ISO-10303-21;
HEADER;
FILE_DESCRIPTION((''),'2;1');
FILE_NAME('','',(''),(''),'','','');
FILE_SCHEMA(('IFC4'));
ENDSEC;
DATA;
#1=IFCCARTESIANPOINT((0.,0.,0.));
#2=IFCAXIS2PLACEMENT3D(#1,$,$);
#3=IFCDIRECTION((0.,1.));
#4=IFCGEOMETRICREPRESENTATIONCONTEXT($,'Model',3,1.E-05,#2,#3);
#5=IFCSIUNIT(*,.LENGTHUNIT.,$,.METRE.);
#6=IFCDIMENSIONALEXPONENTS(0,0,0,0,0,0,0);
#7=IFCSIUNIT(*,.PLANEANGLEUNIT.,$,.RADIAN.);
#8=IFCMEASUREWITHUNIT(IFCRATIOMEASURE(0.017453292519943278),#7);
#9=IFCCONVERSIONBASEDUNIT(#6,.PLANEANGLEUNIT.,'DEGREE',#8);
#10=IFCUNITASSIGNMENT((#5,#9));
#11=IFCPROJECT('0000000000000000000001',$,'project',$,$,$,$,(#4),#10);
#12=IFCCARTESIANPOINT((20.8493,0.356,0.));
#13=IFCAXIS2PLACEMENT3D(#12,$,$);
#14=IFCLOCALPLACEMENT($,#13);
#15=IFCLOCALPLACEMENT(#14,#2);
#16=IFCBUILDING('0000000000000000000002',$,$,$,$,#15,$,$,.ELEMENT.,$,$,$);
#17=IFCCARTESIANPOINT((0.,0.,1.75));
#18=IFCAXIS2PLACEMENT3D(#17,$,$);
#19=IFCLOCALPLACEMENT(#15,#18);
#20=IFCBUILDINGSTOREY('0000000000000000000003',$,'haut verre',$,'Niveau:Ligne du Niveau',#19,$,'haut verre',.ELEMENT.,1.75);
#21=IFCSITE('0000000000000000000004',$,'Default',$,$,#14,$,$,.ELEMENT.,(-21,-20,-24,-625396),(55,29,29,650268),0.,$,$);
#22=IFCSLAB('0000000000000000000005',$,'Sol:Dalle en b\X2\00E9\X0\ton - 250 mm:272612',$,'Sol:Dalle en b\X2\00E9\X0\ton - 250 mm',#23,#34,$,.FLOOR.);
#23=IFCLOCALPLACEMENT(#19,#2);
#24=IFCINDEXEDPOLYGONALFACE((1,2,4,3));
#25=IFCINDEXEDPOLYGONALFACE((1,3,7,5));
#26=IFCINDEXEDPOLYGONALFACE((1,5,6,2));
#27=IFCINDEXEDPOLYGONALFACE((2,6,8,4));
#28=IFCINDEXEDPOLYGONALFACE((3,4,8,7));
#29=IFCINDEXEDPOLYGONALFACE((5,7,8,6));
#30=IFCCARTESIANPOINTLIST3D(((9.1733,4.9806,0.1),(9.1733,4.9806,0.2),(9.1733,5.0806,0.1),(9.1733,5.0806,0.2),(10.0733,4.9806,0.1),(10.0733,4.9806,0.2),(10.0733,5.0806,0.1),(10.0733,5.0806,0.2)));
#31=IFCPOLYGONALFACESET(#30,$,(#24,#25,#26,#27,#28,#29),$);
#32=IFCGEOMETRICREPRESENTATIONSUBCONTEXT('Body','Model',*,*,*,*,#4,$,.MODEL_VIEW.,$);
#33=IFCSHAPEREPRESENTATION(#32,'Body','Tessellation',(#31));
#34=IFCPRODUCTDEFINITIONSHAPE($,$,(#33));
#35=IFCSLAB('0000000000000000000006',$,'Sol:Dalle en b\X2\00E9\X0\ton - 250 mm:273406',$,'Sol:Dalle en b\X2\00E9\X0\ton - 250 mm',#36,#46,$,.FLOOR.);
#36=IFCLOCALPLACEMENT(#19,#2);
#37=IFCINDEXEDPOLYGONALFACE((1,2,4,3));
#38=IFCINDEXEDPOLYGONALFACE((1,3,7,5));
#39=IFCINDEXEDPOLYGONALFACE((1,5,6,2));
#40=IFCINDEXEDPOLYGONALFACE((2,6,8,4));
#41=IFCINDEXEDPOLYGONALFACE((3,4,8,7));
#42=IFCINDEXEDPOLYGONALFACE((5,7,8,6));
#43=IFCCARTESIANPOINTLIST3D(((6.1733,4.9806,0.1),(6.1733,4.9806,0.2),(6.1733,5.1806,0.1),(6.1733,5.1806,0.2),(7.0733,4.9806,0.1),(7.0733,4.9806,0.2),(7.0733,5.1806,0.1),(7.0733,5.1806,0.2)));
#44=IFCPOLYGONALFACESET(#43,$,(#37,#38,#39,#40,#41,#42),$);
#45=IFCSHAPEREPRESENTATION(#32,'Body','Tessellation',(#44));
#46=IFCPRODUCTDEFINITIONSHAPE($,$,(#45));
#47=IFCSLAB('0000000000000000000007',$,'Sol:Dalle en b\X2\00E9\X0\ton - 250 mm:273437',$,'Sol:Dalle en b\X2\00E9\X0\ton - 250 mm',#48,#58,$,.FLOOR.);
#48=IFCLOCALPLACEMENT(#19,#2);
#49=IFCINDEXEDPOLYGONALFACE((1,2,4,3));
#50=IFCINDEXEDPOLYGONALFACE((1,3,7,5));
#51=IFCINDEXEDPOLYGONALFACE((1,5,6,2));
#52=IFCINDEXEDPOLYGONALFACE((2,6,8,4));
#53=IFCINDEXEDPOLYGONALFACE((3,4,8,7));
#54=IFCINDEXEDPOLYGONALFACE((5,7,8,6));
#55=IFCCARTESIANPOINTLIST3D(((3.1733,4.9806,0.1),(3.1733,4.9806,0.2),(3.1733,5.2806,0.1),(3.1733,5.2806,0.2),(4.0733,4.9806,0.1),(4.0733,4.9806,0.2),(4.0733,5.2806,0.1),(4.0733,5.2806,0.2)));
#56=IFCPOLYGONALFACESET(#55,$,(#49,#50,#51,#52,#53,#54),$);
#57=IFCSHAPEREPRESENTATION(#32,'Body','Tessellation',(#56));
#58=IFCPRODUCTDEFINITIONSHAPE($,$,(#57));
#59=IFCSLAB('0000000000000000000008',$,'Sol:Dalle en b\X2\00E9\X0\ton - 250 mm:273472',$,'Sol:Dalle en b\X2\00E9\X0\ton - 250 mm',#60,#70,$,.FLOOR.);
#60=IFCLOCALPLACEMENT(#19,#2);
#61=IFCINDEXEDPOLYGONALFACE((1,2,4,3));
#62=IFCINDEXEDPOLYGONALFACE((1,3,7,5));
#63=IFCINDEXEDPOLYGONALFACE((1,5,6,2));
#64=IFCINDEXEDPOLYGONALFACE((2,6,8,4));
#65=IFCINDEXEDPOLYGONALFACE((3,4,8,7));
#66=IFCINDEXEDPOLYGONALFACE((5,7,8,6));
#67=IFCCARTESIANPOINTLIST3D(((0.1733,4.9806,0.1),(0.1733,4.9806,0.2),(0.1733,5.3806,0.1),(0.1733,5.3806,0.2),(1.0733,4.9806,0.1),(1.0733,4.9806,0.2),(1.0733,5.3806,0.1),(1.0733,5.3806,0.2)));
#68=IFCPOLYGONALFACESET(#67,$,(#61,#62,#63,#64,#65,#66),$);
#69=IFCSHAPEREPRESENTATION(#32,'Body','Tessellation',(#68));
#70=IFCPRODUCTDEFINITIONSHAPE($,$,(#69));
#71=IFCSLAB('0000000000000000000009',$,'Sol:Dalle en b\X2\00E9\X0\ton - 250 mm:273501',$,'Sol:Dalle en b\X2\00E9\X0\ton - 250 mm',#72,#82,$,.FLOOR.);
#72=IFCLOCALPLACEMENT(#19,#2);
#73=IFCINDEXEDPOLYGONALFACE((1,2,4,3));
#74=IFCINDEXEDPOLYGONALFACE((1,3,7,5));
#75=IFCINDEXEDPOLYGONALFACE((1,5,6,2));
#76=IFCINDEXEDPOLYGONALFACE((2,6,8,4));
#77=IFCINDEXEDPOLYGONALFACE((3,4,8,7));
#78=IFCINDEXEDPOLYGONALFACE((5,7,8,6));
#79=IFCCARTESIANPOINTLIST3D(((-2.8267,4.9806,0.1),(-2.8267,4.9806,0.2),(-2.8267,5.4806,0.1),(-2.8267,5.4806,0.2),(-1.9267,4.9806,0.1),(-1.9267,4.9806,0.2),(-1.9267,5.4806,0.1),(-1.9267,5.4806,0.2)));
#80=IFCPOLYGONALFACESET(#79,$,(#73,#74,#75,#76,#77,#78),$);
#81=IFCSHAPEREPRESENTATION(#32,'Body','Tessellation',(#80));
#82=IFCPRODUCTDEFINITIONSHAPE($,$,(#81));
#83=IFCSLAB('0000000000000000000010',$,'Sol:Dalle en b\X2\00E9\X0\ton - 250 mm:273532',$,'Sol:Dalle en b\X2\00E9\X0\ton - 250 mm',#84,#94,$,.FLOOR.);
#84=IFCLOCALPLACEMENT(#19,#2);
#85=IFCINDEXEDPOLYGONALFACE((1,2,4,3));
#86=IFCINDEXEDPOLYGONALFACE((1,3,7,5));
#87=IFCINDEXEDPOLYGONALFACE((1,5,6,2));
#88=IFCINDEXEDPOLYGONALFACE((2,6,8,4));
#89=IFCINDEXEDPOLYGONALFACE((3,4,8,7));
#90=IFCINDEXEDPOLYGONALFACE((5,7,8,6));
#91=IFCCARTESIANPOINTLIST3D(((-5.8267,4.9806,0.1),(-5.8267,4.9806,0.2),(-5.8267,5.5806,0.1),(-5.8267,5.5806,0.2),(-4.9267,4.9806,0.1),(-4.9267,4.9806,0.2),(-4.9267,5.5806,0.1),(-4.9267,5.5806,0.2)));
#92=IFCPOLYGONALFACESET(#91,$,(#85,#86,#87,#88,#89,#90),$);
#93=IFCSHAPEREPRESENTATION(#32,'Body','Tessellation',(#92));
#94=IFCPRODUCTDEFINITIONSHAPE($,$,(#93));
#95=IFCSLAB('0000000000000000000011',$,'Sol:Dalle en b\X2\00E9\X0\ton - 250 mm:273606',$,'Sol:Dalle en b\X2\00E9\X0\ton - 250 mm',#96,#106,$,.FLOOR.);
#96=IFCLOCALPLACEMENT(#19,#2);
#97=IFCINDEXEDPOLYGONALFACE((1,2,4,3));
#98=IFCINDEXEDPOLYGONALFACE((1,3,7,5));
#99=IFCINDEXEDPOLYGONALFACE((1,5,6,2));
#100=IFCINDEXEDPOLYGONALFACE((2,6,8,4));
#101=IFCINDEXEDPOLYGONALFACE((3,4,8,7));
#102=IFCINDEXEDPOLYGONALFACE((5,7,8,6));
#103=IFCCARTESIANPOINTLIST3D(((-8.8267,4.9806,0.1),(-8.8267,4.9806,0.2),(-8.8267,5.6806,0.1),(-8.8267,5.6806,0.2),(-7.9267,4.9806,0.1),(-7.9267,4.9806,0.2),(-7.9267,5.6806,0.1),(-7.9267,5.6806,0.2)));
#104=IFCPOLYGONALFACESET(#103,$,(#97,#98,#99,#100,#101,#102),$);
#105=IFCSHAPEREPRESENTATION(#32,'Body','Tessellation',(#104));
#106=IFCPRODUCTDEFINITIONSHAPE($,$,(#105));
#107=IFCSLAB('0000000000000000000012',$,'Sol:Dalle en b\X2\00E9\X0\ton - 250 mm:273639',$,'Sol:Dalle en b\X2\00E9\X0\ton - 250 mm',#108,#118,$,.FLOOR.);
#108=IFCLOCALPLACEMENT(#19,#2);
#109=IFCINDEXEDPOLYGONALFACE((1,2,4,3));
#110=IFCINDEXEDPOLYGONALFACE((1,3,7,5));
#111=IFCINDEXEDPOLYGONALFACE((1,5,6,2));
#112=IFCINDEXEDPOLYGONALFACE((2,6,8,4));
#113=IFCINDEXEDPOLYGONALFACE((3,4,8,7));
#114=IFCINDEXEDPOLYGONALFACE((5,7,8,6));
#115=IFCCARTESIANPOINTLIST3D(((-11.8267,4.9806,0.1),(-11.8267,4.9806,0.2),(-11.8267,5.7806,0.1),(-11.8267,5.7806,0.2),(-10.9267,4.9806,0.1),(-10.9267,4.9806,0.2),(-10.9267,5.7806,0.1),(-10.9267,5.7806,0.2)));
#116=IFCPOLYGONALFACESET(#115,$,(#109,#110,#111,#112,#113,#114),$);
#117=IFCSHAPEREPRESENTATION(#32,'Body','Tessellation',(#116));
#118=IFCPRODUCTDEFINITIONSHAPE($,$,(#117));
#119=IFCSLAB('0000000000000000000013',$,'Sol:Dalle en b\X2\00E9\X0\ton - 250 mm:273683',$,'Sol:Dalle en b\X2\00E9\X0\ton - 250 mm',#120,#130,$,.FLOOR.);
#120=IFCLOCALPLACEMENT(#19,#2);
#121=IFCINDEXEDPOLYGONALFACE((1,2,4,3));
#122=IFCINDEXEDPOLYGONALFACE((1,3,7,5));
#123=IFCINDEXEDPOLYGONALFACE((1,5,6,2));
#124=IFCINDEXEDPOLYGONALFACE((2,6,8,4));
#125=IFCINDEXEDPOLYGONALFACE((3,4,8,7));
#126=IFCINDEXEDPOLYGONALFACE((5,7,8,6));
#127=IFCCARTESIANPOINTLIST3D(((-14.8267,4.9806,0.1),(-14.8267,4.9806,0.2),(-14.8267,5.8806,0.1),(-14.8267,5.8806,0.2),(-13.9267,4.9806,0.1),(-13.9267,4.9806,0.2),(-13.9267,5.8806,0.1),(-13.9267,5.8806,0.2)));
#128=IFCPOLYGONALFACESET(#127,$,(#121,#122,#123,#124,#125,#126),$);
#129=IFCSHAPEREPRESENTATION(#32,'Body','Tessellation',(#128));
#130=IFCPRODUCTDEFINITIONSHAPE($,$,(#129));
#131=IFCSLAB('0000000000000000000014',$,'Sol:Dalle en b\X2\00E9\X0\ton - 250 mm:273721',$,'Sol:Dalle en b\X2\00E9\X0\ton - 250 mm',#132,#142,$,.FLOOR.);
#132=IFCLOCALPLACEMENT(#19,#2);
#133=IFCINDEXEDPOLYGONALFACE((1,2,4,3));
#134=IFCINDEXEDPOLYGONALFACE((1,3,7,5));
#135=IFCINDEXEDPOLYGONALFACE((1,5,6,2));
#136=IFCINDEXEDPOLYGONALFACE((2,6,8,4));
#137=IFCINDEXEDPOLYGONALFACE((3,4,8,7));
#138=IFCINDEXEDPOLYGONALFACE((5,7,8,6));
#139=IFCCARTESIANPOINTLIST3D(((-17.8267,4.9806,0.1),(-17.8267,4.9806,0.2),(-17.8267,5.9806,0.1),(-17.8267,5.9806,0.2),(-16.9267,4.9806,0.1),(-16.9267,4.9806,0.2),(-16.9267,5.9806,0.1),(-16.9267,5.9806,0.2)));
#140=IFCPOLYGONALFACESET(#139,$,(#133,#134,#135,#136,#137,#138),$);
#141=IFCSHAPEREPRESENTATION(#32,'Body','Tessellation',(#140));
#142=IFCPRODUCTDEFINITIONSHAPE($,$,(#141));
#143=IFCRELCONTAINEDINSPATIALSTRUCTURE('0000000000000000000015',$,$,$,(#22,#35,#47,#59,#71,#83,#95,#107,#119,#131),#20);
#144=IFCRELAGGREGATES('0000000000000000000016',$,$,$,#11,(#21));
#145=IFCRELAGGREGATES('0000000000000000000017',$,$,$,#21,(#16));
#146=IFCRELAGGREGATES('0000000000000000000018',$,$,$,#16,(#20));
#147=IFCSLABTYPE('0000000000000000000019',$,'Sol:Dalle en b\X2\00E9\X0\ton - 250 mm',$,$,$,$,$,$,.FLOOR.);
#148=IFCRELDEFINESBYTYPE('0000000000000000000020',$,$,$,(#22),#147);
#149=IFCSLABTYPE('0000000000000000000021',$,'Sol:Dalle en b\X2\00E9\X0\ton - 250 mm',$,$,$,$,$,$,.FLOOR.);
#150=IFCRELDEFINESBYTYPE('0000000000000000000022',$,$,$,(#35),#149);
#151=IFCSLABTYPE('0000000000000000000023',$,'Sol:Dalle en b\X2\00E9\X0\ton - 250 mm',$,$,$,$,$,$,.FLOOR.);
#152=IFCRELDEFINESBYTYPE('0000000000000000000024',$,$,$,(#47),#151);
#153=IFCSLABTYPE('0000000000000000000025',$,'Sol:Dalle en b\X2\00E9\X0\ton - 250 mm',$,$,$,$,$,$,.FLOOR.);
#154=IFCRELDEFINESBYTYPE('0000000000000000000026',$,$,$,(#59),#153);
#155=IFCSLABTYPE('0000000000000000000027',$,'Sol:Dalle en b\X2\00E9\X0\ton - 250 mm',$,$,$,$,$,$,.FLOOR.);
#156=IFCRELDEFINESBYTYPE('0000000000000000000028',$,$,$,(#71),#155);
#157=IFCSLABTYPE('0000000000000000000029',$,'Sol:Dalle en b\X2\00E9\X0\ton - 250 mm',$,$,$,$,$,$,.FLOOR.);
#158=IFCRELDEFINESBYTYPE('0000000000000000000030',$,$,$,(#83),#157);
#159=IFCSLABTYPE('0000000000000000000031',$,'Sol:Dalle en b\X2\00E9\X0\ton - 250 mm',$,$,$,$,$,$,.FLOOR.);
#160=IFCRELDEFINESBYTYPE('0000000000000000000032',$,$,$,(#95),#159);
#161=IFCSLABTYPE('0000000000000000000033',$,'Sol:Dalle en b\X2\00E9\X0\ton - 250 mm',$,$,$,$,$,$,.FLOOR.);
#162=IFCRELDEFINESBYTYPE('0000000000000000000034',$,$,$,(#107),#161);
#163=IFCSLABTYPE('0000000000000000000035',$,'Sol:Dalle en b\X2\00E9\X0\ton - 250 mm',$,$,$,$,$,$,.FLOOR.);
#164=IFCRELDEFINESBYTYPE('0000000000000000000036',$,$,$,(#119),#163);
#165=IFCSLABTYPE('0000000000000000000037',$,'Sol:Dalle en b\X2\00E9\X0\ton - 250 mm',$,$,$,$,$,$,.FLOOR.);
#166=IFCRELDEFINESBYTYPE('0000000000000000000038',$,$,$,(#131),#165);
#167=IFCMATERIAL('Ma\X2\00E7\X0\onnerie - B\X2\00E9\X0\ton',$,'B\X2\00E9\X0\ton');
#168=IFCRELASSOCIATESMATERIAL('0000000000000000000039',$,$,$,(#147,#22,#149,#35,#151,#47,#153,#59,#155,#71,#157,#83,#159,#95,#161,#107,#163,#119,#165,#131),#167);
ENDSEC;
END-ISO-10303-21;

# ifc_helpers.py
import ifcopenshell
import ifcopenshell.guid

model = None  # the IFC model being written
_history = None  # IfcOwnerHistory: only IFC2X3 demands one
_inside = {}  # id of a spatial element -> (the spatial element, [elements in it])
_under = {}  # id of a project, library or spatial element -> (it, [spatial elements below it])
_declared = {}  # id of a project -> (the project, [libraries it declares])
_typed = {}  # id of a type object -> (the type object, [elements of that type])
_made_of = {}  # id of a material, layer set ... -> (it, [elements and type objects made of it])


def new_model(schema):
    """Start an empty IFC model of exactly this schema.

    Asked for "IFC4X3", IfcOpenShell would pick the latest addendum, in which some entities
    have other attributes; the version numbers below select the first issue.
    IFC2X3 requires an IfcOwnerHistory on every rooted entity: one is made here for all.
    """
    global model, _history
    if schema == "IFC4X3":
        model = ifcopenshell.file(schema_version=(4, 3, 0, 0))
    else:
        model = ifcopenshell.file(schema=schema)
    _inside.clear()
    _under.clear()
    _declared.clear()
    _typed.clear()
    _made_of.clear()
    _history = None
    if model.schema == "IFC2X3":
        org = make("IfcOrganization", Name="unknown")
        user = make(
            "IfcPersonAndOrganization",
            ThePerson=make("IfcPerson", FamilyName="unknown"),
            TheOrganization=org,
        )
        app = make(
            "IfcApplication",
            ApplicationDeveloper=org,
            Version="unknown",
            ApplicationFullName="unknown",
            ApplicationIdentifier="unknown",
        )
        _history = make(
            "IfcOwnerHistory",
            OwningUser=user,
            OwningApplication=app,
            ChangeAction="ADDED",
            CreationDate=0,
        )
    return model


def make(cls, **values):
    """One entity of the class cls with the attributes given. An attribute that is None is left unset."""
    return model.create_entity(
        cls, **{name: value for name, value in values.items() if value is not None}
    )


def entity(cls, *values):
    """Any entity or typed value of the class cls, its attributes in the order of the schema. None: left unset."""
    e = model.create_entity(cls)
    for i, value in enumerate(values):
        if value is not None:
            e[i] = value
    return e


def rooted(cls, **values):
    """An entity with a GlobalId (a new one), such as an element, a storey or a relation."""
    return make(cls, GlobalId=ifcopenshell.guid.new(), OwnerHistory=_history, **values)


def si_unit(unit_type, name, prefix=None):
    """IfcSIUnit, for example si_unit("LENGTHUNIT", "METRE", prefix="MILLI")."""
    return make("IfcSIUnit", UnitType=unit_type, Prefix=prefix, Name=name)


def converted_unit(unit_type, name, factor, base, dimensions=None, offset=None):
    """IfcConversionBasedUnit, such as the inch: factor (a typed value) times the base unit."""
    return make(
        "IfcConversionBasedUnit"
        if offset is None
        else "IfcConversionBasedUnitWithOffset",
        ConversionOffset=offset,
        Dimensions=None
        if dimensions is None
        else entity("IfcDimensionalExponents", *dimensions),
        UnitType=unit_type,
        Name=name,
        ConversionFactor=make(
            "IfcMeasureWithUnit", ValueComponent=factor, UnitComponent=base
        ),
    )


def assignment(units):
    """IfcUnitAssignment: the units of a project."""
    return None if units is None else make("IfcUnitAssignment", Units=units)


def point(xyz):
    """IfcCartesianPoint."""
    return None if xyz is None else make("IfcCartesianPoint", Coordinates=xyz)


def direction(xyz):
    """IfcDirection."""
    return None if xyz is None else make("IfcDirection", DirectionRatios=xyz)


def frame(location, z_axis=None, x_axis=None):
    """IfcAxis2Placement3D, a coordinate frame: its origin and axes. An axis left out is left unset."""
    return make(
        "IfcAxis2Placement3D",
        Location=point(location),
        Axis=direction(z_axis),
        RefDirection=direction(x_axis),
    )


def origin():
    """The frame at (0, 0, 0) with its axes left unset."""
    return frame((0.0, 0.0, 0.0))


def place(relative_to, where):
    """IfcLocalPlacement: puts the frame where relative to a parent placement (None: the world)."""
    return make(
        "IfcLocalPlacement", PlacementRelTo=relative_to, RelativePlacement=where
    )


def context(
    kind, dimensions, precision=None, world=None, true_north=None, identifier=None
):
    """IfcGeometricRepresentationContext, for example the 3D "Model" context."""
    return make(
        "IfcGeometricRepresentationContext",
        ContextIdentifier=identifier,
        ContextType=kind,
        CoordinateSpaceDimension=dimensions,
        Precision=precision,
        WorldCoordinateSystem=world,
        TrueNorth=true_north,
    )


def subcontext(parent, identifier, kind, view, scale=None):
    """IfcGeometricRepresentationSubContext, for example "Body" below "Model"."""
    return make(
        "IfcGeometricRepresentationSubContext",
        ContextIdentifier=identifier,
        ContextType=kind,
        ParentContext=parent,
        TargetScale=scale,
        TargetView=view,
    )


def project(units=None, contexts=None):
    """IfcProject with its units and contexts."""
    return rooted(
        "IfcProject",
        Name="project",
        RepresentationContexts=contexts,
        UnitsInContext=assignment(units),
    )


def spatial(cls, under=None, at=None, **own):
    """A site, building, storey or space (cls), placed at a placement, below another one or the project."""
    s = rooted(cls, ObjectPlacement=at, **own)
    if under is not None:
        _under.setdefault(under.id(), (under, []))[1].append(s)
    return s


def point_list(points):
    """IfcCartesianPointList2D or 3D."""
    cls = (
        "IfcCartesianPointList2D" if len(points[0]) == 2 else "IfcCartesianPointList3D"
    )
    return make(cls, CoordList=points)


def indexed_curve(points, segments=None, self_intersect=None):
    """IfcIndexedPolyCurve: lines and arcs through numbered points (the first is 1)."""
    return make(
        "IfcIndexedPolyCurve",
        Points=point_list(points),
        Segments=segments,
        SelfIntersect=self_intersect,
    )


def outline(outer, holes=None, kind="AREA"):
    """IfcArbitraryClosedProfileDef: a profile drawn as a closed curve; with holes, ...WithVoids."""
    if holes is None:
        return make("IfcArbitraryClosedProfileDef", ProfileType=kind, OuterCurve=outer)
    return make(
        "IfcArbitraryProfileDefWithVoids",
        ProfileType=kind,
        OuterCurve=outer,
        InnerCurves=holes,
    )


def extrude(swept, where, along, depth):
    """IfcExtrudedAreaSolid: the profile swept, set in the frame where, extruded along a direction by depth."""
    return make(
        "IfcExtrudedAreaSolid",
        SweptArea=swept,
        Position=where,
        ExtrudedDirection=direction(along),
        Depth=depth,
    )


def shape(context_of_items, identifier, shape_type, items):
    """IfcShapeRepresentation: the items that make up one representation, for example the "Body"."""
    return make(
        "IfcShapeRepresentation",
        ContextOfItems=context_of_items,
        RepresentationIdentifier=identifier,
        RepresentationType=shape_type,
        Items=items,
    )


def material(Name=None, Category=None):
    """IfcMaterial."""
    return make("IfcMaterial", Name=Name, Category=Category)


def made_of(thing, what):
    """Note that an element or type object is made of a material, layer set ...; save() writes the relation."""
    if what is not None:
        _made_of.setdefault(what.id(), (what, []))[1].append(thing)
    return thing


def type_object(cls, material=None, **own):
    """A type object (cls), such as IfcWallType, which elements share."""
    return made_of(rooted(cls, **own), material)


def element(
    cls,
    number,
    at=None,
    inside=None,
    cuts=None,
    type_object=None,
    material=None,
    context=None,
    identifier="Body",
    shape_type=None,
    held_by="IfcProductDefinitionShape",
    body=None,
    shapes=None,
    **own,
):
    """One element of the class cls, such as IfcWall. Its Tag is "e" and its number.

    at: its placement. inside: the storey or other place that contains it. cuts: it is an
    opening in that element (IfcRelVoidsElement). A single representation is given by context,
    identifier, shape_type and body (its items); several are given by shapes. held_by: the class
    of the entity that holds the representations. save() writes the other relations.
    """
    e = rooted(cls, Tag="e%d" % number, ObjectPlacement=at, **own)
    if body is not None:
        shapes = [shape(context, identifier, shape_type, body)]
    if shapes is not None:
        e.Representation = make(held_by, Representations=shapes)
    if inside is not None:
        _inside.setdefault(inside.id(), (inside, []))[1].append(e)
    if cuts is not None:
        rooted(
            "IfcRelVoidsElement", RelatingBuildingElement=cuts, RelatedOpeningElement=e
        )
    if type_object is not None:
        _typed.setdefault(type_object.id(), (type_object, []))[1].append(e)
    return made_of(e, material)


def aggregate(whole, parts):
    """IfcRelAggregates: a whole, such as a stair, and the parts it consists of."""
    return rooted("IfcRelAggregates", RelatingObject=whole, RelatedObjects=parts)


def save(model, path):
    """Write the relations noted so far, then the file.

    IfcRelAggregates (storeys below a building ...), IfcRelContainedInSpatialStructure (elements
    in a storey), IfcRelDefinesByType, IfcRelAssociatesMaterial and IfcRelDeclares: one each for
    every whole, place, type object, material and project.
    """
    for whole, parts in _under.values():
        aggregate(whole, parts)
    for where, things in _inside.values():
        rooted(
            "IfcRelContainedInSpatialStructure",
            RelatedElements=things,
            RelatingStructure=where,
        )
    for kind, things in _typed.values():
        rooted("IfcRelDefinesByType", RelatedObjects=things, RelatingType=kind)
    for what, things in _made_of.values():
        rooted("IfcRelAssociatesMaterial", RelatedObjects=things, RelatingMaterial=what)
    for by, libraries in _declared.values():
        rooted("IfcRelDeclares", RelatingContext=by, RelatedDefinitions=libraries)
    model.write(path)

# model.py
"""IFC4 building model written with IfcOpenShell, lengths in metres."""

from ifc_helpers import new_model, entity, si_unit, converted_unit, direction, frame, origin, place, context, subcontext, project, spatial, indexed_curve, outline, extrude, material, type_object, element, save


model = new_model("IFC4")

# Units and contexts
model_context = context("Model", 3, precision=1e-05, world=origin(), true_north=direction((0.0, 1.0)))
body_context = subcontext(model_context, "Body", "Model", "MODEL_VIEW")
ifc_project = project(units=[si_unit("LENGTHUNIT", "METRE"), converted_unit("PLANEANGLEUNIT", "DEGREE", entity("IfcRatioMeasure", 0.017453292519943278), si_unit("PLANEANGLEUNIT", "RADIAN"), dimensions=[0, 0, 0, 0, 0, 0, 0])], contexts=[model_context])

# Site, building, storey
site_placement = place(None, frame((20.8493, 0.356, 0.0)))
site = spatial("IfcSite", under=ifc_project, at=site_placement, Name="Default", CompositionType="ELEMENT", RefLatitude=(-21, -20, -24, -625396), RefLongitude=(55, 29, 29, 650268), RefElevation=0.0)
building_placement = place(site_placement, origin())
building = spatial("IfcBuilding", under=site, at=building_placement, CompositionType="ELEMENT")
storey_placement = place(building_placement, frame((0.0, 0.0, 1.75)))
storey = spatial("IfcBuildingStorey", under=building, at=storey_placement, Name="haut verre", ObjectType="Niveau:Ligne du Niveau", LongName="haut verre", CompositionType="ELEMENT", Elevation=1.75)

# Slabs
ifc_material = material(Name="Maçonnerie - Béton", Category="Béton")
slab_type_1 = type_object("IfcSlabType", Name="Sol:Dalle en béton - 250 mm", PredefinedType="FLOOR", material=ifc_material)
slab_1_placement = place(storey_placement, origin())
element("IfcSlab", 1, at=slab_1_placement, inside=storey, type_object=slab_type_1, material=ifc_material, Name="Sol:Dalle en béton - 250 mm:272612", ObjectType="Sol:Dalle en béton - 250 mm", PredefinedType="FLOOR", context=body_context, shape_type="SweptSolid", body=[
    extrude(outline(indexed_curve([(-0.05, -0.45), (0.05, -0.45), (0.05, 0.45), (-0.05, 0.45), (-0.05, -0.45)], self_intersect=False)), frame((9.6233, 5.0306, 0.2), z_axis=(0.0, 0.0, -1.0), x_axis=(0.0, 1.0, 0.0)), (0.0, 0.0, 1.0), 0.1),
])
slab_type_2 = type_object("IfcSlabType", Name="Sol:Dalle en béton - 250 mm", PredefinedType="FLOOR", material=ifc_material)
slab_2_placement = place(storey_placement, origin())
element("IfcSlab", 2, at=slab_2_placement, inside=storey, type_object=slab_type_2, material=ifc_material, Name="Sol:Dalle en béton - 250 mm:273406", ObjectType="Sol:Dalle en béton - 250 mm", PredefinedType="FLOOR", context=body_context, shape_type="SweptSolid", body=[
    extrude(outline(indexed_curve([(-0.1, -0.45), (0.1, -0.45), (0.1, 0.45), (-0.1, 0.45), (-0.1, -0.45)], self_intersect=False)), frame((6.6233, 5.0806, 0.2), z_axis=(0.0, 0.0, -1.0), x_axis=(0.0, 1.0, 0.0)), (0.0, 0.0, 1.0), 0.1),
])
slab_type_3 = type_object("IfcSlabType", Name="Sol:Dalle en béton - 250 mm", PredefinedType="FLOOR", material=ifc_material)
slab_3_placement = place(storey_placement, origin())
element("IfcSlab", 3, at=slab_3_placement, inside=storey, type_object=slab_type_3, material=ifc_material, Name="Sol:Dalle en béton - 250 mm:273437", ObjectType="Sol:Dalle en béton - 250 mm", PredefinedType="FLOOR", context=body_context, shape_type="SweptSolid", body=[
    extrude(outline(indexed_curve([(-0.15, -0.45), (0.15, -0.45), (0.15, 0.45), (-0.15, 0.45), (-0.15, -0.45)], self_intersect=False)), frame((3.6233, 5.1306, 0.2), z_axis=(0.0, 0.0, -1.0), x_axis=(0.0, 1.0, 0.0)), (0.0, 0.0, 1.0), 0.1),
])
slab_type_4 = type_object("IfcSlabType", Name="Sol:Dalle en béton - 250 mm", PredefinedType="FLOOR", material=ifc_material)
slab_4_placement = place(storey_placement, origin())
element("IfcSlab", 4, at=slab_4_placement, inside=storey, type_object=slab_type_4, material=ifc_material, Name="Sol:Dalle en béton - 250 mm:273472", ObjectType="Sol:Dalle en béton - 250 mm", PredefinedType="FLOOR", context=body_context, shape_type="SweptSolid", body=[
    extrude(outline(indexed_curve([(-0.2, -0.45), (0.2, -0.45), (0.2, 0.45), (-0.2, 0.45), (-0.2, -0.45)], self_intersect=False)), frame((0.6233, 5.1806, 0.2), z_axis=(0.0, 0.0, -1.0), x_axis=(0.0, 1.0, 0.0)), (0.0, 0.0, 1.0), 0.1),
])
slab_type_5 = type_object("IfcSlabType", Name="Sol:Dalle en béton - 250 mm", PredefinedType="FLOOR", material=ifc_material)
slab_5_placement = place(storey_placement, origin())
element("IfcSlab", 5, at=slab_5_placement, inside=storey, type_object=slab_type_5, material=ifc_material, Name="Sol:Dalle en béton - 250 mm:273501", ObjectType="Sol:Dalle en béton - 250 mm", PredefinedType="FLOOR", context=body_context, shape_type="SweptSolid", body=[
    extrude(outline(indexed_curve([(-0.25, -0.45), (0.25, -0.45), (0.25, 0.45), (-0.25, 0.45), (-0.25, -0.45)], self_intersect=False)), frame((-2.3767, 5.2306, 0.2), z_axis=(0.0, 0.0, -1.0), x_axis=(0.0, 1.0, 0.0)), (0.0, 0.0, 1.0), 0.1),
])
slab_type_6 = type_object("IfcSlabType", Name="Sol:Dalle en béton - 250 mm", PredefinedType="FLOOR", material=ifc_material)
slab_6_placement = place(storey_placement, origin())
element("IfcSlab", 6, at=slab_6_placement, inside=storey, type_object=slab_type_6, material=ifc_material, Name="Sol:Dalle en béton - 250 mm:273532", ObjectType="Sol:Dalle en béton - 250 mm", PredefinedType="FLOOR", context=body_context, shape_type="SweptSolid", body=[
    extrude(outline(indexed_curve([(-0.3, -0.45), (0.3, -0.45), (0.3, 0.45), (-0.3, 0.45), (-0.3, -0.45)], self_intersect=False)), frame((-5.3767, 5.2806, 0.2), z_axis=(0.0, 0.0, -1.0), x_axis=(0.0, 1.0, 0.0)), (0.0, 0.0, 1.0), 0.1),
])
slab_type_7 = type_object("IfcSlabType", Name="Sol:Dalle en béton - 250 mm", PredefinedType="FLOOR", material=ifc_material)
slab_7_placement = place(storey_placement, origin())
element("IfcSlab", 7, at=slab_7_placement, inside=storey, type_object=slab_type_7, material=ifc_material, Name="Sol:Dalle en béton - 250 mm:273606", ObjectType="Sol:Dalle en béton - 250 mm", PredefinedType="FLOOR", context=body_context, shape_type="SweptSolid", body=[
    extrude(outline(indexed_curve([(-0.35, -0.45), (0.35, -0.45), (0.35, 0.45), (-0.35, 0.45), (-0.35, -0.45)], self_intersect=False)), frame((-8.3767, 5.3306, 0.2), z_axis=(0.0, 0.0, -1.0), x_axis=(0.0, 1.0, 0.0)), (0.0, 0.0, 1.0), 0.1),
])
slab_type_8 = type_object("IfcSlabType", Name="Sol:Dalle en béton - 250 mm", PredefinedType="FLOOR", material=ifc_material)
slab_8_placement = place(storey_placement, origin())
element("IfcSlab", 8, at=slab_8_placement, inside=storey, type_object=slab_type_8, material=ifc_material, Name="Sol:Dalle en béton - 250 mm:273639", ObjectType="Sol:Dalle en béton - 250 mm", PredefinedType="FLOOR", context=body_context, shape_type="SweptSolid", body=[
    extrude(outline(indexed_curve([(-0.4, -0.45), (0.4, -0.45), (0.4, 0.45), (-0.4, 0.45), (-0.4, -0.45)], self_intersect=False)), frame((-11.3767, 5.3806, 0.2), z_axis=(0.0, 0.0, -1.0), x_axis=(0.0, 1.0, 0.0)), (0.0, 0.0, 1.0), 0.1),
])
slab_type_9 = type_object("IfcSlabType", Name="Sol:Dalle en béton - 250 mm", PredefinedType="FLOOR", material=ifc_material)
slab_9_placement = place(storey_placement, origin())
element("IfcSlab", 9, at=slab_9_placement, inside=storey, type_object=slab_type_9, material=ifc_material, Name="Sol:Dalle en béton - 250 mm:273683", ObjectType="Sol:Dalle en béton - 250 mm", PredefinedType="FLOOR", context=body_context, shape_type="SweptSolid", body=[
    extrude(outline(indexed_curve([(-0.45, -0.45), (0.45, -0.45), (0.45, 0.45), (-0.45, 0.45), (-0.45, -0.45)], self_intersect=False)), frame((-14.3767, 5.4306, 0.2), z_axis=(0.0, 0.0, -1.0), x_axis=(0.0, 1.0, 0.0)), (0.0, 0.0, 1.0), 0.1),
])
slab_type_10 = type_object("IfcSlabType", Name="Sol:Dalle en béton - 250 mm", PredefinedType="FLOOR", material=ifc_material)
slab_10_placement = place(storey_placement, origin())
element("IfcSlab", 10, at=slab_10_placement, inside=storey, type_object=slab_type_10, material=ifc_material, Name="Sol:Dalle en béton - 250 mm:273721", ObjectType="Sol:Dalle en béton - 250 mm", PredefinedType="FLOOR", context=body_context, shape_type="SweptSolid", body=[
    extrude(outline(indexed_curve([(-0.5, -0.45), (0.5, -0.45), (0.5, 0.45), (-0.5, 0.45), (-0.5, -0.45)], self_intersect=False)), frame((-17.3767, 5.4806, 0.2), z_axis=(0.0, 0.0, -1.0), x_axis=(0.0, 1.0, 0.0)), (0.0, 0.0, 1.0), 0.1),
])

save(model, "model.ifc")
